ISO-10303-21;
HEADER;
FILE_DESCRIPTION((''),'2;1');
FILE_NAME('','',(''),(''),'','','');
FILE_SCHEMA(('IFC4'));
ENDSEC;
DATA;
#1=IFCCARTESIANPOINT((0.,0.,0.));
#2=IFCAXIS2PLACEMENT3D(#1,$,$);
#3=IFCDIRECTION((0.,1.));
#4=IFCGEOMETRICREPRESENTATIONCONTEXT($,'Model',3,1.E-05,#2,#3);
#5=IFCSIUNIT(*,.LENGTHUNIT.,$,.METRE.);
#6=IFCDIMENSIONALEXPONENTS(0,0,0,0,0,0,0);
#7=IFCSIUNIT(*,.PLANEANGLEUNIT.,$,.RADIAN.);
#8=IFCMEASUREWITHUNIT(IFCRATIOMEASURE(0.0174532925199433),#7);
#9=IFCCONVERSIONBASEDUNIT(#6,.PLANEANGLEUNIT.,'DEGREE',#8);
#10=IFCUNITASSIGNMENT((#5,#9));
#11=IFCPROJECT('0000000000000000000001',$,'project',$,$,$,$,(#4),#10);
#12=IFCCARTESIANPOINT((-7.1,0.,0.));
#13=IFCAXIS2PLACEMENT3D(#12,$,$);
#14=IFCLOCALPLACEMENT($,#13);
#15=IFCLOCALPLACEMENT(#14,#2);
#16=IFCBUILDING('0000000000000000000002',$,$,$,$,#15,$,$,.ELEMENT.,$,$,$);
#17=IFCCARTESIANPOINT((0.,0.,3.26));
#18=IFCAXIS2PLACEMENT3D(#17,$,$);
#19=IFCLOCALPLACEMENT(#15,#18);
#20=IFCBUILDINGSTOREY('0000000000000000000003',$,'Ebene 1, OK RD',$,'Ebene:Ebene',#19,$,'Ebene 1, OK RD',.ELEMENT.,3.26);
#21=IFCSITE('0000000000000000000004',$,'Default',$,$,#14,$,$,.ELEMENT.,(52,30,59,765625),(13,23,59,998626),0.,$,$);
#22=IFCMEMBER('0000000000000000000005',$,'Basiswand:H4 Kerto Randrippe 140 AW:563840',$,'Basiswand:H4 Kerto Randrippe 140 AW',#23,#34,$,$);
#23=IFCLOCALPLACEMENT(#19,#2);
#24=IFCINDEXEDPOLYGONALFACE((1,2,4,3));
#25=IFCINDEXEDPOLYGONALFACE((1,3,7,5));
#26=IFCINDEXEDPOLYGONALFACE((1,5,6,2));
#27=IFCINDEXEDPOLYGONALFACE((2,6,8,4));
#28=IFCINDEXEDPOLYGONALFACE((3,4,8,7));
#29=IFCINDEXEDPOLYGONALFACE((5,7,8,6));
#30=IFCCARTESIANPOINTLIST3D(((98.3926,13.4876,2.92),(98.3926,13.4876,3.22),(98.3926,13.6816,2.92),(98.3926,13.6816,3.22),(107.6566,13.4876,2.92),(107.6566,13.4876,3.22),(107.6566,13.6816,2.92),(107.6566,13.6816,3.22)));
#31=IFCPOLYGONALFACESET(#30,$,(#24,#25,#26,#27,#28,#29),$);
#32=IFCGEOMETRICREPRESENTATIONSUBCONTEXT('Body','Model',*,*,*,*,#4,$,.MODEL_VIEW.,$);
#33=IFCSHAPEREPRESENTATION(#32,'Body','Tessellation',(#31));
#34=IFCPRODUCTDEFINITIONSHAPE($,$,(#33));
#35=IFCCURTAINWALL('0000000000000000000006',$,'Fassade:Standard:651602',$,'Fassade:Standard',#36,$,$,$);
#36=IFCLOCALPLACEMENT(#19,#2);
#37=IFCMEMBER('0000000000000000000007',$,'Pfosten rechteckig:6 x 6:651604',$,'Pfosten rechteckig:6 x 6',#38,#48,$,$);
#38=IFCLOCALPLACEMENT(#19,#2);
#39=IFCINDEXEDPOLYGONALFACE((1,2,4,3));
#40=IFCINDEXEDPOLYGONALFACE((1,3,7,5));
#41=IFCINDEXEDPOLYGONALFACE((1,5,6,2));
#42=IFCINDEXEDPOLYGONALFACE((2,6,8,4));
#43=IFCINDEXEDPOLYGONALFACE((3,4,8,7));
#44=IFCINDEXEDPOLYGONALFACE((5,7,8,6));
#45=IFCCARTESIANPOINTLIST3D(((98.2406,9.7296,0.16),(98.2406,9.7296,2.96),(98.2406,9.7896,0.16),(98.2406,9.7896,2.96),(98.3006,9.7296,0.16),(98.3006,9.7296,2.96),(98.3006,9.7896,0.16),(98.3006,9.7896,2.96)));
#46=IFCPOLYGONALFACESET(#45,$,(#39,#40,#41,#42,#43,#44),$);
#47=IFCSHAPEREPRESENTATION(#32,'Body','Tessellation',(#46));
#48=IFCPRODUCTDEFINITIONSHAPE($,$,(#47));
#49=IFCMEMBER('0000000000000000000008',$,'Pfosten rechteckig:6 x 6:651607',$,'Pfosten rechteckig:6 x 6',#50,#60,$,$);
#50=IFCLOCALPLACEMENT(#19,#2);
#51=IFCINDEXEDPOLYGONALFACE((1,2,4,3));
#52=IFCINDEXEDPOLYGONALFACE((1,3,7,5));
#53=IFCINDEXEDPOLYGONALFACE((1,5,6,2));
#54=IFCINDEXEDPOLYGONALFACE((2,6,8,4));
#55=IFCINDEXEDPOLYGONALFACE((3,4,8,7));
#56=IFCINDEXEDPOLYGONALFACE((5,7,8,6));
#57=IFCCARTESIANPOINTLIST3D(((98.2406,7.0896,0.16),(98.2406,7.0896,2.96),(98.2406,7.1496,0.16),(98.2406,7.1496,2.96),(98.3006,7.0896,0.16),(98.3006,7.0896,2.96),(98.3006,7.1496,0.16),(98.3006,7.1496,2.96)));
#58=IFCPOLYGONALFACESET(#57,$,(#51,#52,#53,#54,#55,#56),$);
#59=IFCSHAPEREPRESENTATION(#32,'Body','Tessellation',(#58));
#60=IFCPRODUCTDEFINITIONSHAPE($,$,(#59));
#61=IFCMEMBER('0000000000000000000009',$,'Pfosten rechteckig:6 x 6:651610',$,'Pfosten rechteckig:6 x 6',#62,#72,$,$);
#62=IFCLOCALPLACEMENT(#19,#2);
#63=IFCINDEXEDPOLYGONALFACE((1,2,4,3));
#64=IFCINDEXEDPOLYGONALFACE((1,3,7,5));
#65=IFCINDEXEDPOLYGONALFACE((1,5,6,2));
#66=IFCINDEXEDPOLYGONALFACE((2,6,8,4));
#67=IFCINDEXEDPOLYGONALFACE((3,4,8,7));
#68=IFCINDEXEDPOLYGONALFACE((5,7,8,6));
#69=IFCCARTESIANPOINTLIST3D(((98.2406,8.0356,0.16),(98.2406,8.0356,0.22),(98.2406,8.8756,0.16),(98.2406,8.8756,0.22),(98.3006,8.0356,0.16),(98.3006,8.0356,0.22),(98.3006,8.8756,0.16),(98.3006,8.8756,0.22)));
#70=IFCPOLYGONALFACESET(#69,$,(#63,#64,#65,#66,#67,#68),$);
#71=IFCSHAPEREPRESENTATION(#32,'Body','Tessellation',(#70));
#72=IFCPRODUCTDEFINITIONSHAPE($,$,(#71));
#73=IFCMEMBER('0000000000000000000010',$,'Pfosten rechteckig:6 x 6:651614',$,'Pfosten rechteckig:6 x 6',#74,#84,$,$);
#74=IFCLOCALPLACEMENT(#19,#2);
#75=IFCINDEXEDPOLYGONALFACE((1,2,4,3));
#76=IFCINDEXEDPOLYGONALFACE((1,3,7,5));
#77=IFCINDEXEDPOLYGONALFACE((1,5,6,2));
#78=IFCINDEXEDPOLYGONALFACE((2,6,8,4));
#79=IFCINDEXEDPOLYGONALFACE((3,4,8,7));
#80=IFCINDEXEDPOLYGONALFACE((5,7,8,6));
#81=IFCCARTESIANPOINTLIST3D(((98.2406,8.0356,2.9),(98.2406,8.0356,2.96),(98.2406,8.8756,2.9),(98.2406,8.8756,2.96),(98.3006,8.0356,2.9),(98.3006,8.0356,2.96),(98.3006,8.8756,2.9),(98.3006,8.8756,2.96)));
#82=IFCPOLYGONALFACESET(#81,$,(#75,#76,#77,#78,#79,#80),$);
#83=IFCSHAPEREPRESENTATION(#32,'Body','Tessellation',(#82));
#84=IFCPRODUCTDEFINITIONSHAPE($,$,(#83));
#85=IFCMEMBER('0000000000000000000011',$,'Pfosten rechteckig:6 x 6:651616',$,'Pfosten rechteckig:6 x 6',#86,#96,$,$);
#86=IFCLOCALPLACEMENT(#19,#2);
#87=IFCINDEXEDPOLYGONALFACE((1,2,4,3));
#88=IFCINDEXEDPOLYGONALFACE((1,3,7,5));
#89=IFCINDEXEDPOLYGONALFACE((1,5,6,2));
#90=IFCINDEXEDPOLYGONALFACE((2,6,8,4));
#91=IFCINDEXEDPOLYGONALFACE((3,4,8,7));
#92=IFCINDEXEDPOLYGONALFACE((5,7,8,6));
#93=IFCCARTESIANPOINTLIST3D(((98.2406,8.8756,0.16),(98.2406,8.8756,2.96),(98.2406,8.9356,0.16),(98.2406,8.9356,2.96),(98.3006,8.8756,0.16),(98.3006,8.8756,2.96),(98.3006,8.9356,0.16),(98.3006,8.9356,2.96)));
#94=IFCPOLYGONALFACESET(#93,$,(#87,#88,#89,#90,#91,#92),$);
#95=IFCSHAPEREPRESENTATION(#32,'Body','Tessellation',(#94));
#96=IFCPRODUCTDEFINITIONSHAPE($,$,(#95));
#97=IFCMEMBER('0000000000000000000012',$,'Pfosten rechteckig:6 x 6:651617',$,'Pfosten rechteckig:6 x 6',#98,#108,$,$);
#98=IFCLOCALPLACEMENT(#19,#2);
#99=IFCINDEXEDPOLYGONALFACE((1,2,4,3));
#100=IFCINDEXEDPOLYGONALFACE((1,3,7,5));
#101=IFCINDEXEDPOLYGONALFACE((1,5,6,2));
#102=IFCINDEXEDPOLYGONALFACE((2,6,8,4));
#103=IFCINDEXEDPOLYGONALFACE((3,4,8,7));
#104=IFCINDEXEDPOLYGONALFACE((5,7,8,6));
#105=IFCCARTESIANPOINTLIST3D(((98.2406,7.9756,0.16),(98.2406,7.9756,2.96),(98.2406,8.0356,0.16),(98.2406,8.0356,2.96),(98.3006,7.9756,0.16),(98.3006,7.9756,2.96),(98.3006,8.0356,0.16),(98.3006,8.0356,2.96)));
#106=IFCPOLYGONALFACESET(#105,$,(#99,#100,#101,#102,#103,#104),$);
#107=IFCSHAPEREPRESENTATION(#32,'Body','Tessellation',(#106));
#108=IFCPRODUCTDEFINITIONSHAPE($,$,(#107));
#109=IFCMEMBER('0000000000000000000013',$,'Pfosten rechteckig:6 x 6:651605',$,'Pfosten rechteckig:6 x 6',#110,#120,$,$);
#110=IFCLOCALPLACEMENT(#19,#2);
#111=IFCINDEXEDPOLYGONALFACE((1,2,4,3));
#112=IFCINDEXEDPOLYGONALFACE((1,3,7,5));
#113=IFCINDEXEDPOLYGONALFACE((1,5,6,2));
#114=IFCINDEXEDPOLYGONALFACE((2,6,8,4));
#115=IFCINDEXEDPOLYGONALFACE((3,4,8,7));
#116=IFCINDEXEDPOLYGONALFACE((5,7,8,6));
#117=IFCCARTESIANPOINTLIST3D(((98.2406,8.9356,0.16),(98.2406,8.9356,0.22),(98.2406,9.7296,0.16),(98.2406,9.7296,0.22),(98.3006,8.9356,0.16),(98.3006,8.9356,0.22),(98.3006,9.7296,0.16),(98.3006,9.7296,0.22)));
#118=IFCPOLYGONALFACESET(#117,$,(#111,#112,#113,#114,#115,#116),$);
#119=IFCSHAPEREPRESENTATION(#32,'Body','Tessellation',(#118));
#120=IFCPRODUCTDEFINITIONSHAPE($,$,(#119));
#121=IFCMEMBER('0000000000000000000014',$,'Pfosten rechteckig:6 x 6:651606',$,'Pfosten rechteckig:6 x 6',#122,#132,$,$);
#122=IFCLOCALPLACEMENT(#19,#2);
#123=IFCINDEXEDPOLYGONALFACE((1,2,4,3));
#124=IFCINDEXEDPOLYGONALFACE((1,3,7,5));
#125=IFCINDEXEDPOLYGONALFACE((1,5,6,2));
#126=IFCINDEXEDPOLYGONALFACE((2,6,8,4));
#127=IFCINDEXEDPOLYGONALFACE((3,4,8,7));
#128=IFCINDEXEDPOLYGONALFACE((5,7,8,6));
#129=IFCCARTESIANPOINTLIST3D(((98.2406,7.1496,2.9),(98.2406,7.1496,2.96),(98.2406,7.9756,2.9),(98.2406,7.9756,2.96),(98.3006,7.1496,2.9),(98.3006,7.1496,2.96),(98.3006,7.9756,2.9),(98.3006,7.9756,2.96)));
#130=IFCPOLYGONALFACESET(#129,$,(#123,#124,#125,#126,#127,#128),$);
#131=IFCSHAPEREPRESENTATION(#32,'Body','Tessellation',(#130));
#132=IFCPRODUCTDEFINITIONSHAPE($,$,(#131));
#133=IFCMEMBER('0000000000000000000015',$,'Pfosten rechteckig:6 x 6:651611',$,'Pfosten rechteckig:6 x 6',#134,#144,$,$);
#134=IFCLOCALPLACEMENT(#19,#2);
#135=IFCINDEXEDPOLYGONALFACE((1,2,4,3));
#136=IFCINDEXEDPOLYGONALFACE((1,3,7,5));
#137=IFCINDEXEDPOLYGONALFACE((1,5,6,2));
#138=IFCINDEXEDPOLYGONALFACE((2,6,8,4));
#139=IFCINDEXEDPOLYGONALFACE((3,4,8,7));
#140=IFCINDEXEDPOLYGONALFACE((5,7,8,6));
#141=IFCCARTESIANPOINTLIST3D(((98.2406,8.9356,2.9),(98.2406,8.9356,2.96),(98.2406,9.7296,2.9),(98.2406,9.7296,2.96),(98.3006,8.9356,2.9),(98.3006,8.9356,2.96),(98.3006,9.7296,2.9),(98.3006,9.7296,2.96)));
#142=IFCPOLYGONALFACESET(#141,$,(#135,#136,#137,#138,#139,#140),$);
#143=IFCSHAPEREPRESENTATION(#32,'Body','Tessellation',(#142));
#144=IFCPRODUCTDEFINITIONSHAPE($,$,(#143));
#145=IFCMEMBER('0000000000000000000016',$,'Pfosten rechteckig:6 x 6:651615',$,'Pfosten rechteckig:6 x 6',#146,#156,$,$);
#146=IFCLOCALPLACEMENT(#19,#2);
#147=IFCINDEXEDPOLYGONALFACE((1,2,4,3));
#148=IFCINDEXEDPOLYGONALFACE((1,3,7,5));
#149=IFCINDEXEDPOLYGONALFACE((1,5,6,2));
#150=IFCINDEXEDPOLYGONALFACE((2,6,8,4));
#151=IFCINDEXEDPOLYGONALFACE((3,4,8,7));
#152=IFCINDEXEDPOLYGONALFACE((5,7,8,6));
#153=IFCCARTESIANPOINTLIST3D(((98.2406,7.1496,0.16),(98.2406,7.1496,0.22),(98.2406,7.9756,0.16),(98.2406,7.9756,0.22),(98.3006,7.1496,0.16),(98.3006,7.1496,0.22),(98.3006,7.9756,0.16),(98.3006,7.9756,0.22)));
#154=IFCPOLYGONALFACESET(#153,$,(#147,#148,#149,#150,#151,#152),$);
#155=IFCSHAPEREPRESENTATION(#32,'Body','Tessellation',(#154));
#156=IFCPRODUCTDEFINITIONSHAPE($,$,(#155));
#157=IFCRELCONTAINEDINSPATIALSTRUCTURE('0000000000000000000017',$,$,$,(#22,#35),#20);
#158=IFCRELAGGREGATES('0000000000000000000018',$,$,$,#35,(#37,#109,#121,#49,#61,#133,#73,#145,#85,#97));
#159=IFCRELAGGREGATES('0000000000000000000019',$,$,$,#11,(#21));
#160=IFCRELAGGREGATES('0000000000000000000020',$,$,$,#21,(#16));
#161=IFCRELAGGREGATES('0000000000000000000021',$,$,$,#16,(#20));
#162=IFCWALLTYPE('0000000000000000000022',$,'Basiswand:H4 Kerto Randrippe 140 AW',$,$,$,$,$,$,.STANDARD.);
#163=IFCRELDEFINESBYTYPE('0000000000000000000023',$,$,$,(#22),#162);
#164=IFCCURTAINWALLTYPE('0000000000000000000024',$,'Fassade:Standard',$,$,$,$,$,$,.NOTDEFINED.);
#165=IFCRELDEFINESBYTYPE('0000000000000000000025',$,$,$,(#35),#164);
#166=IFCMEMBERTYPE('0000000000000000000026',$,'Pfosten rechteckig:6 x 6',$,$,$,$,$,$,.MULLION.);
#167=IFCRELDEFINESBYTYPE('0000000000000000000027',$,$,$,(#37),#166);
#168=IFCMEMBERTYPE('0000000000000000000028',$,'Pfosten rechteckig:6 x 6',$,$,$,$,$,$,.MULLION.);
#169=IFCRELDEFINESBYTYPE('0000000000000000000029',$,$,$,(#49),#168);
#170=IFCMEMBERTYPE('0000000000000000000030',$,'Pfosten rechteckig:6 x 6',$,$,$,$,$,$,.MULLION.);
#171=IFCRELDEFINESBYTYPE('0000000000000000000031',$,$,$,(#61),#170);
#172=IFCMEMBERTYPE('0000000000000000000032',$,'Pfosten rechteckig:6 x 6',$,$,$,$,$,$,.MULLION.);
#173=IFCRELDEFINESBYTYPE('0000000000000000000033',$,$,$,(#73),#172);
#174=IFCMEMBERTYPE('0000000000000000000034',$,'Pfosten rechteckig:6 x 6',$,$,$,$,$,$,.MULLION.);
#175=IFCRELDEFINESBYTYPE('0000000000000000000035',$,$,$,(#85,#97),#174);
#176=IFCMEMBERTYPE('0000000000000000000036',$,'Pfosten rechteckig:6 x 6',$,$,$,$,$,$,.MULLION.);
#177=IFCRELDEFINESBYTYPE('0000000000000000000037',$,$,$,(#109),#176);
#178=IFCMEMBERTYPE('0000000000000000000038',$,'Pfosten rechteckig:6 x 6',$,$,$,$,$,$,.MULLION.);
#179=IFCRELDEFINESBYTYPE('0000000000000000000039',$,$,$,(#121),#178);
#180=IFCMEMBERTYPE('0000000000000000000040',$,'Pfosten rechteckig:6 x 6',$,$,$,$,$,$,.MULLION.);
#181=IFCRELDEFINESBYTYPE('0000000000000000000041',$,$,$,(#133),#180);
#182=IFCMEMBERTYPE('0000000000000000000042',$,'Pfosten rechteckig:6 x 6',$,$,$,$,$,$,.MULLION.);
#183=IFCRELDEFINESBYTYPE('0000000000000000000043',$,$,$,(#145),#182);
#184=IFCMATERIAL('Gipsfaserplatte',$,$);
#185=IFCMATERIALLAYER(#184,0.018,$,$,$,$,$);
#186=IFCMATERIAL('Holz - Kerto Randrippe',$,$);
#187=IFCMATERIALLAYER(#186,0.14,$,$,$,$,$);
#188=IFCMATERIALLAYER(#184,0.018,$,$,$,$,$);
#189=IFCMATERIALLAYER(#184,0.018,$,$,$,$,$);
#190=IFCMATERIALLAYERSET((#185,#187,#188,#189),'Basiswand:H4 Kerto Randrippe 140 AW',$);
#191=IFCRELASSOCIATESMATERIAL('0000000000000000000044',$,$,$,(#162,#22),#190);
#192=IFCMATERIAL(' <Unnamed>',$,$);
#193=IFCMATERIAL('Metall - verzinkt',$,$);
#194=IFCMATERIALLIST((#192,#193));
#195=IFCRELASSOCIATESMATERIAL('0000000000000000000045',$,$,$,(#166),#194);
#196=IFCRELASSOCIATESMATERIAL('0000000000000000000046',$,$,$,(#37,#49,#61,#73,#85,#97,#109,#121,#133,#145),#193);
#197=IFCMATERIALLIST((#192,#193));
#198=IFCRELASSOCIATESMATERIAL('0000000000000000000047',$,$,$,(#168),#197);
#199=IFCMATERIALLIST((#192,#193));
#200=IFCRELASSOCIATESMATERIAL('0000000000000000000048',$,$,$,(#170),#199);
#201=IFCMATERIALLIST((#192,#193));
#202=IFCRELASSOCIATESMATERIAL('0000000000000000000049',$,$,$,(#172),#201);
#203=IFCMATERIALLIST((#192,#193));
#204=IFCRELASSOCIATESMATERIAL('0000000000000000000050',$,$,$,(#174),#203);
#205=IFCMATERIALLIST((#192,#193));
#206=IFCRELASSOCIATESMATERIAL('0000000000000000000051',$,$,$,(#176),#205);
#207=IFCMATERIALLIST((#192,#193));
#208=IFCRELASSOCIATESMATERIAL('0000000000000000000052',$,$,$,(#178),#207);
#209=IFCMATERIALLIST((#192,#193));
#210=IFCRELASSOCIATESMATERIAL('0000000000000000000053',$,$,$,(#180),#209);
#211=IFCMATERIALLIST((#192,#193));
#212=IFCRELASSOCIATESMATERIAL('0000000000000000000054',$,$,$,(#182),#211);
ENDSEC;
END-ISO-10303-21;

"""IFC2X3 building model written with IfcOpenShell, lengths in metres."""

from ifc_helpers import new_model, entity, si_unit, converted_unit, direction, frame, frame_2d, origin, origin_2d_with_axis, place, context, subcontext, project, spatial, rectangle, extrude, source, transform, mapped, material, material_list, layer, layer_set, layer_usage, type_object, type_shapes, element, aggregate, save


model = new_model("IFC2X3")

# Units and contexts
model_context = context("Model", 3, precision=1e-05, world=origin(), true_north=direction((0.0, 1.0)))
body_context = subcontext(model_context, "Body", "Model", "MODEL_VIEW")
ifc_project = project(units=[si_unit("LENGTHUNIT", "METRE"), converted_unit("PLANEANGLEUNIT", "DEGREE", entity("IfcRatioMeasure", 0.0174532925199433), si_unit("PLANEANGLEUNIT", "RADIAN"), dimensions=[0, 0, 0, 0, 0, 0, 0])], contexts=[model_context])

# Site, building, storey
site_placement = place(None, frame((-7.1, 0.0, 0.0)))
site = spatial("IfcSite", under=ifc_project, at=site_placement, Name="Default", CompositionType="ELEMENT", RefLatitude=(52, 30, 59, 765625), RefLongitude=(13, 23, 59, 998626), RefElevation=0.0)
building_placement = place(site_placement, origin())
building = spatial("IfcBuilding", under=site, at=building_placement, CompositionType="ELEMENT")
storey_placement = place(building_placement, frame((0.0, 0.0, 3.26)))
storey = spatial("IfcBuildingStorey", under=building, at=storey_placement, Name="Ebene 1, OK RD", ObjectType="Ebene:Ebene", LongName="Ebene 1, OK RD", CompositionType="ELEMENT", Elevation=3.26)

# Member
ifc_material_1 = material(Name="Gipsfaserplatte")
ifc_layer_1 = layer(ifc_material_1, 0.018)
ifc_material_2 = material(Name="Holz - Kerto Randrippe")
ifc_layer_2 = layer(ifc_material_2, 0.14)
ifc_layer_3 = layer(ifc_material_1, 0.018)
ifc_layer_4 = layer(ifc_material_1, 0.018)
ifc_layer_set_1 = layer_set([ifc_layer_1, ifc_layer_2, ifc_layer_3, ifc_layer_4], Name="Basiswand:H4 Kerto Randrippe 140 AW")
ifc_layer_usage_1 = layer_usage(ifc_layer_set_1, "AXIS2", "NEGATIVE", 0.097)
wall_type_1 = type_object("IfcWallType", Name="Basiswand:H4 Kerto Randrippe 140 AW", PredefinedType="STANDARD", material=ifc_layer_set_1)
member_1_placement = place(storey_placement, frame((98.3926, 13.5846, 2.92)))
element("IfcMember", 1, at=member_1_placement, inside=storey, type_object=wall_type_1, material=ifc_layer_usage_1, Name="Basiswand:H4 Kerto Randrippe 140 AW:563840", ObjectType="Basiswand:H4 Kerto Randrippe 140 AW", context=body_context, shape_type="SweptSolid", body=[
    extrude(rectangle(XDim=9.264, YDim=0.194, at=frame_2d((4.632, 0.0), x_axis=(-1.0, 0.0))), origin(), (0.0, 0.0, 1.0), 0.3),
])

# Curtain wall, members
curtain_wall_type = type_object("IfcCurtainWallType", Name="Fassade:Standard", PredefinedType="NOTDEFINED")
curtain_wall_placement = place(storey_placement, frame((0.0, 0.0, -3.26)))
curtain_wall = element("IfcCurtainWall", 2, at=curtain_wall_placement, inside=storey, type_object=curtain_wall_type, Name="Fassade:Standard:651602", ObjectType="Fassade:Standard")
ifc_material_3 = material(Name="Metall - verzinkt")
ifc_material_4 = material(Name=" <Unnamed>")
ifc_material_list_1 = material_list([ifc_material_4, ifc_material_3])
member_type_1 = type_object("IfcMemberType", Name="Pfosten rechteckig:6 x 6", PredefinedType="MULLION", material=ifc_material_list_1)
shared_shape_1 = source(origin(), body_context, "Body", "SweptSolid", [
    extrude(rectangle(XDim=0.06, YDim=0.06, at=origin_2d_with_axis()), frame((-0.03, 0.0, -2.8), z_axis=(0.0, 0.0, 1.0), x_axis=(0.0, -1.0, 0.0)), (0.0, 0.0, 1.0), 2.8),
])
type_shapes(member_type_1, [shared_shape_1])
member_2_placement = place(storey_placement, frame((98.2706, 9.7896, 2.96), z_axis=(0.0, 0.0, 1.0), x_axis=(0.0, 1.0, 0.0)))
member_2 = element("IfcMember", 3, at=member_2_placement, type_object=member_type_1, material=ifc_material_3, Name="Pfosten rechteckig:6 x 6:651604", ObjectType="Pfosten rechteckig:6 x 6", context=body_context, shape_type="MappedRepresentation", body=[
    mapped(shared_shape_1, transform((0.0, 0.0, 0.0), scale=1.0)),
])
ifc_material_list_2 = material_list([ifc_material_4, ifc_material_3])
member_type_2 = type_object("IfcMemberType", Name="Pfosten rechteckig:6 x 6", PredefinedType="MULLION", material=ifc_material_list_2)
shared_shape_2 = source(origin(), body_context, "Body", "SweptSolid", [
    extrude(rectangle(XDim=0.06, YDim=0.06, at=origin_2d_with_axis()), frame((-0.03, 0.0, -2.8), z_axis=(0.0, 0.0, 1.0), x_axis=(0.0, -1.0, 0.0)), (0.0, 0.0, 1.0), 2.8),
])
type_shapes(member_type_2, [shared_shape_2])
member_3_placement = place(storey_placement, frame((98.2706, 7.0896, 0.16), z_axis=(0.0, 0.0, -1.0), x_axis=(0.0, -1.0, 0.0)))
member_3 = element("IfcMember", 4, at=member_3_placement, type_object=member_type_2, material=ifc_material_3, Name="Pfosten rechteckig:6 x 6:651607", ObjectType="Pfosten rechteckig:6 x 6", context=body_context, shape_type="MappedRepresentation", body=[
    mapped(shared_shape_2, transform((0.0, 0.0, 0.0), scale=1.0)),
])
ifc_material_list_3 = material_list([ifc_material_4, ifc_material_3])
member_type_3 = type_object("IfcMemberType", Name="Pfosten rechteckig:6 x 6", PredefinedType="MULLION", material=ifc_material_list_3)
shared_shape_3 = source(origin(), body_context, "Body", "SweptSolid", [
    extrude(rectangle(XDim=0.06, YDim=0.06, at=origin_2d_with_axis()), frame((-0.03, 0.0, -0.84), z_axis=(0.0, 0.0, 1.0), x_axis=(0.0, -1.0, 0.0)), (0.0, 0.0, 1.0), 0.84),
])
type_shapes(member_type_3, [shared_shape_3])
member_4_placement = place(storey_placement, frame((98.2706, 8.8756, 0.16), z_axis=(0.0, 1.0, 0.0), x_axis=(0.0, 0.0, -1.0)))
member_4 = element("IfcMember", 5, at=member_4_placement, type_object=member_type_3, material=ifc_material_3, Name="Pfosten rechteckig:6 x 6:651610", ObjectType="Pfosten rechteckig:6 x 6", context=body_context, shape_type="MappedRepresentation", body=[
    mapped(shared_shape_3, transform((0.0, 0.0, 0.0), scale=1.0)),
])
ifc_material_list_4 = material_list([ifc_material_4, ifc_material_3])
member_type_4 = type_object("IfcMemberType", Name="Pfosten rechteckig:6 x 6", PredefinedType="MULLION", material=ifc_material_list_4)
shared_shape_4 = source(origin(), body_context, "Body", "SweptSolid", [
    extrude(rectangle(XDim=0.06, YDim=0.06, at=origin_2d_with_axis()), frame((-0.03, 0.0, -0.84), z_axis=(0.0, 0.0, 1.0), x_axis=(0.0, -1.0, 0.0)), (0.0, 0.0, 1.0), 0.84),
])
type_shapes(member_type_4, [shared_shape_4])
member_5_placement = place(storey_placement, frame((98.2706, 8.0356, 2.96), z_axis=(0.0, -1.0, 0.0), x_axis=(0.0, 0.0, 1.0)))
member_5 = element("IfcMember", 6, at=member_5_placement, type_object=member_type_4, material=ifc_material_3, Name="Pfosten rechteckig:6 x 6:651614", ObjectType="Pfosten rechteckig:6 x 6", context=body_context, shape_type="MappedRepresentation", body=[
    mapped(shared_shape_4, transform((0.0, 0.0, 0.0), scale=1.0)),
])
ifc_material_list_5 = material_list([ifc_material_4, ifc_material_3])
member_type_5 = type_object("IfcMemberType", Name="Pfosten rechteckig:6 x 6", PredefinedType="MULLION", material=ifc_material_list_5)
shared_shape_5 = source(origin(), body_context, "Body", "SweptSolid", [
    extrude(rectangle(XDim=0.06, YDim=0.06, at=origin_2d_with_axis()), frame((0.0, 0.0, -2.8), z_axis=(0.0, 0.0, 1.0), x_axis=(0.0, -1.0, 0.0)), (0.0, 0.0, 1.0), 2.8),
])
type_shapes(member_type_5, [shared_shape_5])
member_6_placement = place(storey_placement, frame((98.2706, 8.9056, 0.16), z_axis=(0.0, 0.0, -1.0), x_axis=(0.0, -1.0, 0.0)))
member_6 = element("IfcMember", 7, at=member_6_placement, type_object=member_type_5, material=ifc_material_3, Name="Pfosten rechteckig:6 x 6:651616", ObjectType="Pfosten rechteckig:6 x 6", context=body_context, shape_type="MappedRepresentation", body=[
    mapped(shared_shape_5, transform((0.0, 0.0, 0.0), scale=1.0)),
])
member_7_placement = place(storey_placement, frame((98.2706, 8.0056, 0.16), z_axis=(0.0, 0.0, -1.0), x_axis=(0.0, -1.0, 0.0)))
member_7 = element("IfcMember", 8, at=member_7_placement, type_object=member_type_5, material=ifc_material_3, Name="Pfosten rechteckig:6 x 6:651617", ObjectType="Pfosten rechteckig:6 x 6", context=body_context, shape_type="MappedRepresentation", body=[
    mapped(shared_shape_5, transform((0.0, 0.0, 0.0), scale=1.0)),
])
ifc_material_list_6 = material_list([ifc_material_4, ifc_material_3])
member_type_6 = type_object("IfcMemberType", Name="Pfosten rechteckig:6 x 6", PredefinedType="MULLION", material=ifc_material_list_6)
shared_shape_6 = source(origin(), body_context, "Body", "SweptSolid", [
    extrude(rectangle(XDim=0.06, YDim=0.06, at=origin_2d_with_axis()), frame((-0.03, 0.0, -0.794), z_axis=(0.0, 0.0, 1.0), x_axis=(0.0, -1.0, 0.0)), (0.0, 0.0, 1.0), 0.794),
])
type_shapes(member_type_6, [shared_shape_6])
member_8_placement = place(storey_placement, frame((98.2706, 9.7296, 0.16), z_axis=(0.0, 1.0, 0.0), x_axis=(0.0, 0.0, -1.0)))
member_8 = element("IfcMember", 9, at=member_8_placement, type_object=member_type_6, material=ifc_material_3, Name="Pfosten rechteckig:6 x 6:651605", ObjectType="Pfosten rechteckig:6 x 6", context=body_context, shape_type="MappedRepresentation", body=[
    mapped(shared_shape_6, transform((0.0, 0.0, 0.0), scale=1.0)),
])
ifc_material_list_7 = material_list([ifc_material_4, ifc_material_3])
member_type_7 = type_object("IfcMemberType", Name="Pfosten rechteckig:6 x 6", PredefinedType="MULLION", material=ifc_material_list_7)
shared_shape_7 = source(origin(), body_context, "Body", "SweptSolid", [
    extrude(rectangle(XDim=0.06, YDim=0.06, at=origin_2d_with_axis()), frame((-0.03, 0.0, -0.826), z_axis=(0.0, 0.0, 1.0), x_axis=(0.0, -1.0, 0.0)), (0.0, 0.0, 1.0), 0.826),
])
type_shapes(member_type_7, [shared_shape_7])
member_9_placement = place(storey_placement, frame((98.2706, 7.1496, 2.96), z_axis=(0.0, -1.0, 0.0), x_axis=(0.0, 0.0, 1.0)))
member_9 = element("IfcMember", 10, at=member_9_placement, type_object=member_type_7, material=ifc_material_3, Name="Pfosten rechteckig:6 x 6:651606", ObjectType="Pfosten rechteckig:6 x 6", context=body_context, shape_type="MappedRepresentation", body=[
    mapped(shared_shape_7, transform((0.0, 0.0, 0.0), scale=1.0)),
])
ifc_material_list_8 = material_list([ifc_material_4, ifc_material_3])
member_type_8 = type_object("IfcMemberType", Name="Pfosten rechteckig:6 x 6", PredefinedType="MULLION", material=ifc_material_list_8)
shared_shape_8 = source(origin(), body_context, "Body", "SweptSolid", [
    extrude(rectangle(XDim=0.06, YDim=0.06, at=origin_2d_with_axis()), frame((-0.03, 0.0, -0.794), z_axis=(0.0, 0.0, 1.0), x_axis=(0.0, -1.0, 0.0)), (0.0, 0.0, 1.0), 0.794),
])
type_shapes(member_type_8, [shared_shape_8])
member_10_placement = place(storey_placement, frame((98.2706, 8.9356, 2.96), z_axis=(0.0, -1.0, 0.0), x_axis=(0.0, 0.0, 1.0)))
member_10 = element("IfcMember", 11, at=member_10_placement, type_object=member_type_8, material=ifc_material_3, Name="Pfosten rechteckig:6 x 6:651611", ObjectType="Pfosten rechteckig:6 x 6", context=body_context, shape_type="MappedRepresentation", body=[
    mapped(shared_shape_8, transform((0.0, 0.0, 0.0), scale=1.0)),
])
ifc_material_list_9 = material_list([ifc_material_4, ifc_material_3])
member_type_9 = type_object("IfcMemberType", Name="Pfosten rechteckig:6 x 6", PredefinedType="MULLION", material=ifc_material_list_9)
shared_shape_9 = source(origin(), body_context, "Body", "SweptSolid", [
    extrude(rectangle(XDim=0.06, YDim=0.06, at=origin_2d_with_axis()), frame((-0.03, 0.0, -0.826), z_axis=(0.0, 0.0, 1.0), x_axis=(0.0, -1.0, 0.0)), (0.0, 0.0, 1.0), 0.826),
])
type_shapes(member_type_9, [shared_shape_9])
member_11_placement = place(storey_placement, frame((98.2706, 7.9756, 0.16), z_axis=(0.0, 1.0, 0.0), x_axis=(0.0, 0.0, -1.0)))
member_11 = element("IfcMember", 12, at=member_11_placement, type_object=member_type_9, material=ifc_material_3, Name="Pfosten rechteckig:6 x 6:651615", ObjectType="Pfosten rechteckig:6 x 6", context=body_context, shape_type="MappedRepresentation", body=[
    mapped(shared_shape_9, transform((0.0, 0.0, 0.0), scale=1.0)),
])

aggregate(curtain_wall, [member_2, member_8, member_9, member_3, member_4, member_10, member_5, member_11, member_6, member_7])

save(model, "model.ifc")
